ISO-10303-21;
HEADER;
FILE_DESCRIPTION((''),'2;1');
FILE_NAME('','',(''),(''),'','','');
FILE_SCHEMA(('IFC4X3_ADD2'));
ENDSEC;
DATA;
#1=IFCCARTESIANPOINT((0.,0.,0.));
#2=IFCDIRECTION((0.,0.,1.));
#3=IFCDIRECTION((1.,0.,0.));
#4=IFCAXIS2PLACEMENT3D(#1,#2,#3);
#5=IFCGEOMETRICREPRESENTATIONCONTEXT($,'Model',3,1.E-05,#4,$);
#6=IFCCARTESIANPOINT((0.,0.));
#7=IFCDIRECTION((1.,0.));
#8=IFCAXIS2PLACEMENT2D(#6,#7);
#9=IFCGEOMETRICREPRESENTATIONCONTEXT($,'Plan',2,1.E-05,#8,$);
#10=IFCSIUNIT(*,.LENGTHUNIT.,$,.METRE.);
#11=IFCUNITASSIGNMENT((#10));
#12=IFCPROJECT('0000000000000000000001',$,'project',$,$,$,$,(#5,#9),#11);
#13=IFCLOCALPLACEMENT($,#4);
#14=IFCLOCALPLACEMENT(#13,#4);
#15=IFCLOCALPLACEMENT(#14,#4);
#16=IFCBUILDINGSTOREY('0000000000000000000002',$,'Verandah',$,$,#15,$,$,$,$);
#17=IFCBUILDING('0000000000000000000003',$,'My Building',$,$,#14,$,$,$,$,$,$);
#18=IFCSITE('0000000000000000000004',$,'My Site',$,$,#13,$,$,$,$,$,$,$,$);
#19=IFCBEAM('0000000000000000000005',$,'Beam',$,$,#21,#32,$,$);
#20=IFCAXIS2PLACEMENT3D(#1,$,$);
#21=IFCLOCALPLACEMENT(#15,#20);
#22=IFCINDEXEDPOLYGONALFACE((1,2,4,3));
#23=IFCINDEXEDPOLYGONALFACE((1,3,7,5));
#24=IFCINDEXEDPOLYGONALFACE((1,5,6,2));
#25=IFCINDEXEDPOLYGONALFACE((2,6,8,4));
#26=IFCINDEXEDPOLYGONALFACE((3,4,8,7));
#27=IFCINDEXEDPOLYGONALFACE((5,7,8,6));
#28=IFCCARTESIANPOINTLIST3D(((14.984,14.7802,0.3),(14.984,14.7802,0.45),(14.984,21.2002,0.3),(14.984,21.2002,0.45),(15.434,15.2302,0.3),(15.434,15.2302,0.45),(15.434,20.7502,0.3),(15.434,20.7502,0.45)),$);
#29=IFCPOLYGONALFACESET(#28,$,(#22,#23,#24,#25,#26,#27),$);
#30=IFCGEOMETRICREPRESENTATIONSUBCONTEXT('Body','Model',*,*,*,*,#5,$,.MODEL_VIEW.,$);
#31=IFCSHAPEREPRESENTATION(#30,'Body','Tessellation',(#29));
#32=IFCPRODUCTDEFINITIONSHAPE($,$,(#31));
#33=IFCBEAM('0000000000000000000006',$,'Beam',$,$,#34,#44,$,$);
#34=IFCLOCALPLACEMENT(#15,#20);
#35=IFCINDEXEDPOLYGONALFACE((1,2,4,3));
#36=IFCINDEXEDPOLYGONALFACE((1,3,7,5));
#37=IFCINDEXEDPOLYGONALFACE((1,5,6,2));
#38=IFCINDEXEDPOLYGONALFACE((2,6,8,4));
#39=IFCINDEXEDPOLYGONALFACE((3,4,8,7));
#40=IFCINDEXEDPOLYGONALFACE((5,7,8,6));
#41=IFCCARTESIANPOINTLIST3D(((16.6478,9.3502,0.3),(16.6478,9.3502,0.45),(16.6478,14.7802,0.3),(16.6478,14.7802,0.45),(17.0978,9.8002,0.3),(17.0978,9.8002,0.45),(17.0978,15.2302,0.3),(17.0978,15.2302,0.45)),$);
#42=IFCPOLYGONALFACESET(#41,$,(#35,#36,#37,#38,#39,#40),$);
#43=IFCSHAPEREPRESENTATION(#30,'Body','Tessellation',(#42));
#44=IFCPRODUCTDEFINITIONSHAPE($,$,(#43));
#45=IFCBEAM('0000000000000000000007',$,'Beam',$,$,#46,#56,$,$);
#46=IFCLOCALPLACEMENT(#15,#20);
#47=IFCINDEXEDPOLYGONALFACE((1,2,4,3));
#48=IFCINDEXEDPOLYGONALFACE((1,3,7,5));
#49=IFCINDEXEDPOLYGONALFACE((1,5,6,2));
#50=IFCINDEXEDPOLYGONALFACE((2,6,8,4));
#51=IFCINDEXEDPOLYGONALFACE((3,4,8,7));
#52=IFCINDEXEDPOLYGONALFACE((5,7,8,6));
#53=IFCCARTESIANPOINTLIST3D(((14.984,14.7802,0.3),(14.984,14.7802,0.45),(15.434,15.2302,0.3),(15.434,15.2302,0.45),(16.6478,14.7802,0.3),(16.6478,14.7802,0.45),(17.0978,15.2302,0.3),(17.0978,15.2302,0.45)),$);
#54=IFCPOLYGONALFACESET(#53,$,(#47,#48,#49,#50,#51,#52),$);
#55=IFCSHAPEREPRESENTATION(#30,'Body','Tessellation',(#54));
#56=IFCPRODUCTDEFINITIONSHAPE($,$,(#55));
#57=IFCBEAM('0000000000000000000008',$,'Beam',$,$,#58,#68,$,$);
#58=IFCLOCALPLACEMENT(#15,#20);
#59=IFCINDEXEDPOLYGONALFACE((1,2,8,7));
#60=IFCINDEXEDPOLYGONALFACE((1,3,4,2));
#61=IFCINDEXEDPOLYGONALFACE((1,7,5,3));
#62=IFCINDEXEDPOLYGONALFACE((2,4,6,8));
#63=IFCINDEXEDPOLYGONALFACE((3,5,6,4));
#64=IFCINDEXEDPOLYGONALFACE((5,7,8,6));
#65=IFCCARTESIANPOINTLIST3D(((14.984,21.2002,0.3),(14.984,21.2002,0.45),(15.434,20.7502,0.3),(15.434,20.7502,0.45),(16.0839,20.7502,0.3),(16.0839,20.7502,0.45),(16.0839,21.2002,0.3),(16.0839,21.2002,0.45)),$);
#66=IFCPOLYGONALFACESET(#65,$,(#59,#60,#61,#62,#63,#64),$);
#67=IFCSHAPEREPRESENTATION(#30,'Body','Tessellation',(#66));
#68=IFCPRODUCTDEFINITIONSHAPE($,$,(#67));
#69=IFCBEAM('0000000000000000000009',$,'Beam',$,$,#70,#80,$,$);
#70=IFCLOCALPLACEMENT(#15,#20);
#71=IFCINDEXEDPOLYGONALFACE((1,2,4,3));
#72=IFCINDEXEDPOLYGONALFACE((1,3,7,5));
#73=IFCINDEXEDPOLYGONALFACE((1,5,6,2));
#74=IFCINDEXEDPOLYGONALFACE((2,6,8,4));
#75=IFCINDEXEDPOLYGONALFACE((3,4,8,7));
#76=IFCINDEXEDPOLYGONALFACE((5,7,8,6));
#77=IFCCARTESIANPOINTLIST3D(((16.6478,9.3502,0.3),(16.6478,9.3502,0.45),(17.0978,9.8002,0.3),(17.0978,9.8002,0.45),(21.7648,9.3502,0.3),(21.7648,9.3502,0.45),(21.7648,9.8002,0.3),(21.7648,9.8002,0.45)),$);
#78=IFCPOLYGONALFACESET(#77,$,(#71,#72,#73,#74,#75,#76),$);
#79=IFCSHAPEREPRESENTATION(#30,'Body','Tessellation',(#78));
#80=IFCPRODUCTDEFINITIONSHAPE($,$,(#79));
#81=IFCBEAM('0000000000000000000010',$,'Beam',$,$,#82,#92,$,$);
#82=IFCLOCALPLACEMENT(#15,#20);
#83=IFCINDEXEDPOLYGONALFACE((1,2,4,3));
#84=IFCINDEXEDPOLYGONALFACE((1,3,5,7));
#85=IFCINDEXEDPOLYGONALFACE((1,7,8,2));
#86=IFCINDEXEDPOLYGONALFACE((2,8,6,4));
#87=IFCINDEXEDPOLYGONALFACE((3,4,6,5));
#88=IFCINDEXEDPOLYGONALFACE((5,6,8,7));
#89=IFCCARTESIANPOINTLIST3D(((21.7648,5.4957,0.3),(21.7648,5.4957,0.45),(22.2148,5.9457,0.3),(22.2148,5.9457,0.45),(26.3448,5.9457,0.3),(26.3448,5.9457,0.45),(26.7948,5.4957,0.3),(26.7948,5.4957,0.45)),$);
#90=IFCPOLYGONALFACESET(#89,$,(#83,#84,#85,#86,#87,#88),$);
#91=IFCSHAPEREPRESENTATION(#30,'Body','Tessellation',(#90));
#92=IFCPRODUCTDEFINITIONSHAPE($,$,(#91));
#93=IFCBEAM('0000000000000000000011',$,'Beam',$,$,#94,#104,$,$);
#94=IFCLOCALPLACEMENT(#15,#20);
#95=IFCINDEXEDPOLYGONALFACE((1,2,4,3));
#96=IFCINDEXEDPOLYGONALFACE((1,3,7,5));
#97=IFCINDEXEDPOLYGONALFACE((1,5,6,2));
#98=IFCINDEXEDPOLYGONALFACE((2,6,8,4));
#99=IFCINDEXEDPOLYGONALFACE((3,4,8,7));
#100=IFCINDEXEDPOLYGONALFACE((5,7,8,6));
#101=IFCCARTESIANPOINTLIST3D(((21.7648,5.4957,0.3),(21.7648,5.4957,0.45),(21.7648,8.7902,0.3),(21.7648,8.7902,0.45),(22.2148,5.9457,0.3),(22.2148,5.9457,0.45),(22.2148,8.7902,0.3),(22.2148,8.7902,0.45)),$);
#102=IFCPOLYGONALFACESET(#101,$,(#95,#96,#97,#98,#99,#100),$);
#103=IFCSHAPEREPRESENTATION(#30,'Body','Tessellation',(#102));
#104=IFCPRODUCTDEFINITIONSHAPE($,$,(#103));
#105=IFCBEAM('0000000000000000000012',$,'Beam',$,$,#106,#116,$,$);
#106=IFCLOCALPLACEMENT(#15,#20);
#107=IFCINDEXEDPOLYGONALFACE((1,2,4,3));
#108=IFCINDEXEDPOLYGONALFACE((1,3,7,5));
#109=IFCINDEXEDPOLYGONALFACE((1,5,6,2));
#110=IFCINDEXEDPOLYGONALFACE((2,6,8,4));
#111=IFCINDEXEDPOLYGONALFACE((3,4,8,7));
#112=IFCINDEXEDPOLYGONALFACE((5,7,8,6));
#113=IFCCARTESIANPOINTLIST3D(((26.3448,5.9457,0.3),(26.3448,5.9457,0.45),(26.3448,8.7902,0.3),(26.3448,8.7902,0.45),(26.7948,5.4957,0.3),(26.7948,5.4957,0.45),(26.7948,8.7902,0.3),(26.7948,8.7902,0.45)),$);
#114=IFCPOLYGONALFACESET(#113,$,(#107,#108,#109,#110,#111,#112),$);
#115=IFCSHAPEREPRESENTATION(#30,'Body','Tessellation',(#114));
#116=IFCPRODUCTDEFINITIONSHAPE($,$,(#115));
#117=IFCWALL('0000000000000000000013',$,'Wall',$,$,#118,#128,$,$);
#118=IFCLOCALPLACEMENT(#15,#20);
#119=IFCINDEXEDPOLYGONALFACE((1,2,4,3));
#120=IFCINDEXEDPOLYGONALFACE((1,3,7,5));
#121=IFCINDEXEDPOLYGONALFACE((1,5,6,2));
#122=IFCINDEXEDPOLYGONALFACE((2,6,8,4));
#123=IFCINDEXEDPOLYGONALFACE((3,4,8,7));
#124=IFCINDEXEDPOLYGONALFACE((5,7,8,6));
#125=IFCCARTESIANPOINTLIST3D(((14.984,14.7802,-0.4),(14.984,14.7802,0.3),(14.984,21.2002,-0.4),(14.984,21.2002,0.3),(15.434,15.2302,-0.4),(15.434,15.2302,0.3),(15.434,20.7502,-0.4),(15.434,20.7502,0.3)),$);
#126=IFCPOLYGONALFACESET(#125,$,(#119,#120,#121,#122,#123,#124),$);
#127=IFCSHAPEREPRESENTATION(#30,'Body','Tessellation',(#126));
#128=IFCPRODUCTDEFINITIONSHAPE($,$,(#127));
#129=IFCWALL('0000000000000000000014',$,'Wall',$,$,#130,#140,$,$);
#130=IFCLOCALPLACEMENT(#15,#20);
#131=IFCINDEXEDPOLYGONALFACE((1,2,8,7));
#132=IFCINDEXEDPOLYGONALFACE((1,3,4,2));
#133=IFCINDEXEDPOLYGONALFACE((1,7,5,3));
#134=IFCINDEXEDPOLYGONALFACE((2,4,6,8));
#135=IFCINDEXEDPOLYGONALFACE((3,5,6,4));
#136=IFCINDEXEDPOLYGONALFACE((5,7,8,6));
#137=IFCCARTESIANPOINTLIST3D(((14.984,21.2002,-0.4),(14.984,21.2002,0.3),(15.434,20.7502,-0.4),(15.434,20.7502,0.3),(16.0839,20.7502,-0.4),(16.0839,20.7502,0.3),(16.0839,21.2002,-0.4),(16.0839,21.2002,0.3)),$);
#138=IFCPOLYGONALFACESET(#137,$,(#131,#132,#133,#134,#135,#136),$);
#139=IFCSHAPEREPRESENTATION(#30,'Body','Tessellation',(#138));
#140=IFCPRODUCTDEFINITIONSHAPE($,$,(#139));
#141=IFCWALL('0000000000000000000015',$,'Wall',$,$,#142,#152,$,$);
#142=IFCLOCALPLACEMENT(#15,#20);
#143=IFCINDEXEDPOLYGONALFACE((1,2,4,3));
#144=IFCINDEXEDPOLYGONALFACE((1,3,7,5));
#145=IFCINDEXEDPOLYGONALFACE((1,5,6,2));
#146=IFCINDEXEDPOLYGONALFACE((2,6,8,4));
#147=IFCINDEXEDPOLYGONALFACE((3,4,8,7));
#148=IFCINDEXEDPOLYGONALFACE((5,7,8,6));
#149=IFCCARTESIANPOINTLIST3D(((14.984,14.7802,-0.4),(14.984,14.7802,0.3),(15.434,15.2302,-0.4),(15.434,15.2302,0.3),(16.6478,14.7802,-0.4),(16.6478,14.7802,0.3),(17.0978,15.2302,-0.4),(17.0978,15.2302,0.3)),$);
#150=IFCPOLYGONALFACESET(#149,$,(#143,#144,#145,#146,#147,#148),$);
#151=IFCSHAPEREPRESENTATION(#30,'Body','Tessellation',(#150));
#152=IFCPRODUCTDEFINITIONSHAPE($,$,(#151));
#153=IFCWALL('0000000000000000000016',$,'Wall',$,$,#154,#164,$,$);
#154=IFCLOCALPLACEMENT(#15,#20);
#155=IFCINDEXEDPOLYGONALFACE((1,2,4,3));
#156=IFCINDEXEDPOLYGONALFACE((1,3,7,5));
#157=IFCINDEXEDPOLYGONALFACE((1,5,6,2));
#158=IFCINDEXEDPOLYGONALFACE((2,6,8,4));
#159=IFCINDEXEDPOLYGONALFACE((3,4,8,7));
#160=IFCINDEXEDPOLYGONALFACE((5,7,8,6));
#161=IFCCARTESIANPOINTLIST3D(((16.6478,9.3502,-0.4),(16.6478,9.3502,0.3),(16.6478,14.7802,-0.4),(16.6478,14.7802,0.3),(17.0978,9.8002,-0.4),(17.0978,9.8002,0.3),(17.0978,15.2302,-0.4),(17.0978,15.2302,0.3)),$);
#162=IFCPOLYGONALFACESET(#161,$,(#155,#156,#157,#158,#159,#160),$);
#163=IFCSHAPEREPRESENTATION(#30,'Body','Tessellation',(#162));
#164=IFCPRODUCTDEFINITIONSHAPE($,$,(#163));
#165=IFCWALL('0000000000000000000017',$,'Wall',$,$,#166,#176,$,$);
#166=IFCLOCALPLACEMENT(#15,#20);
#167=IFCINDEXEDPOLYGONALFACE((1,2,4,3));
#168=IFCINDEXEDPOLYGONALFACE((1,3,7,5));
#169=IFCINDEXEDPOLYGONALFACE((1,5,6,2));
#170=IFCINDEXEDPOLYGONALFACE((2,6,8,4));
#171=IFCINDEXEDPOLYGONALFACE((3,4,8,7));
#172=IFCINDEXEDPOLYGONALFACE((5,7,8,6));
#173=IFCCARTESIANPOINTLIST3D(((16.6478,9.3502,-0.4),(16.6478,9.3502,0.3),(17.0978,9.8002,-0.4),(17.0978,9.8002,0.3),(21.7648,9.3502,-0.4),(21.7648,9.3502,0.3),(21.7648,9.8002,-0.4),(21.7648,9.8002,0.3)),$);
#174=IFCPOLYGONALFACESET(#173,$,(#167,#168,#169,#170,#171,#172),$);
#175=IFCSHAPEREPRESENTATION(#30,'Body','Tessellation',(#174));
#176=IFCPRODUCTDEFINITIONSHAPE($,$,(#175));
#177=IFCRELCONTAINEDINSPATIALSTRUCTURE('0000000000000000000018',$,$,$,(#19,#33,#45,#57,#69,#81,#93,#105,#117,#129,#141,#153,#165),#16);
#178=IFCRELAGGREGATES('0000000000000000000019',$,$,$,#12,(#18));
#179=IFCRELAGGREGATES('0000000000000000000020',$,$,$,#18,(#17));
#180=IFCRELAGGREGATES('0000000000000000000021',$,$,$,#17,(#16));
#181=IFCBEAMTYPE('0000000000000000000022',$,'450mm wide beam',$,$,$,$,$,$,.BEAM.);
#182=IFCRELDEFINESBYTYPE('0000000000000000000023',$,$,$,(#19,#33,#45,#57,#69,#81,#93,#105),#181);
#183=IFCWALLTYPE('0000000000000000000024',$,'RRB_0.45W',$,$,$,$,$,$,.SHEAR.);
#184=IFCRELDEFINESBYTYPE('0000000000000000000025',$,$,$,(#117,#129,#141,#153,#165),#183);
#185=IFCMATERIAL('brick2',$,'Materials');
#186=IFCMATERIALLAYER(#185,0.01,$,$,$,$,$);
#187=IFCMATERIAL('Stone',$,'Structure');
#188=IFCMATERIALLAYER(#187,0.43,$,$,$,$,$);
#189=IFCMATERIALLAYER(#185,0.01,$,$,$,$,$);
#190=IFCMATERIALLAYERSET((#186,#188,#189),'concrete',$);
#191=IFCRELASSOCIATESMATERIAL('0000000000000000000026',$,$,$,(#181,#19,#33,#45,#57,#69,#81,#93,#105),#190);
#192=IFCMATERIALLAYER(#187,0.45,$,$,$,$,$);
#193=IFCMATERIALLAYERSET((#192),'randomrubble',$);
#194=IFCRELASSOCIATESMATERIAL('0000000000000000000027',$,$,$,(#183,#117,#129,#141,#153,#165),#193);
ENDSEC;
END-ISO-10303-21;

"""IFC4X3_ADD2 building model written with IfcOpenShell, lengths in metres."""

from ifc_helpers import new_model, si_unit, frame, origin_with_axes, origin_2d_with_axis, place, context, subcontext, project, spatial, line, indexed_curve, outline, extrude, material, layer, layer_set, layer_usage, type_object, element, save


model = new_model("IFC4X3_ADD2")

# Units and contexts
model_context = context("Model", 3, precision=1e-05, world=origin_with_axes())
plan_context = context("Plan", 2, precision=1e-05, world=origin_2d_with_axis())
body_context = subcontext(model_context, "Body", "Model", "MODEL_VIEW")
ifc_project = project(units=[si_unit("LENGTHUNIT", "METRE")], contexts=[model_context, plan_context])

# Site, building, storey
site_placement = place(None, origin_with_axes())
site = spatial("IfcSite", under=ifc_project, at=site_placement, Name="My Site")
building_placement = place(site_placement, origin_with_axes())
building = spatial("IfcBuilding", under=site, at=building_placement, Name="My Building")
storey_placement = place(building_placement, origin_with_axes())
storey = spatial("IfcBuildingStorey", under=building, at=storey_placement, Name="Verandah")

# Beams
ifc_material_1 = material(Name="brick2", Category="Materials")
ifc_layer_1 = layer(ifc_material_1, 0.01)
ifc_material_2 = material(Name="Stone", Category="Structure")
ifc_layer_2 = layer(ifc_material_2, 0.43)
ifc_layer_3 = layer(ifc_material_1, 0.01)
ifc_layer_set_1 = layer_set([ifc_layer_1, ifc_layer_2, ifc_layer_3], Name="concrete")
ifc_layer_usage_1 = layer_usage(ifc_layer_set_1, "AXIS2", "POSITIVE", 0.0)
beam_type = type_object("IfcBeamType", Name="450mm wide beam", PredefinedType="BEAM", material=ifc_layer_set_1)
beam_1_placement = place(storey_placement, frame((14.984, 21.2002, 0.3), z_axis=(0.0, 0.0, 1.0), x_axis=(0.0, -1.0, 0.0)))
element("IfcBeam", 1, at=beam_1_placement, inside=storey, type_object=beam_type, material=ifc_layer_usage_1, Name="Beam", context=body_context, shape_type="SweptSolid", body=[
    extrude(outline(indexed_curve([(0.0, 0.0), (0.45, 0.45), (5.97, 0.45), (6.42, 0.0)], segments=[line(1, 2, 3, 4, 1)])), origin_with_axes(), (0.0, 0.0, 1.0), 0.15),
])
ifc_layer_usage_2 = layer_usage(ifc_layer_set_1, "AXIS2", "POSITIVE", 0.0)
beam_2_placement = place(storey_placement, frame((16.6478, 15.2302, 0.3), z_axis=(0.0, 0.0, 1.0), x_axis=(0.0, -1.0, 0.0)))
element("IfcBeam", 2, at=beam_2_placement, inside=storey, type_object=beam_type, material=ifc_layer_usage_2, Name="Beam", context=body_context, shape_type="SweptSolid", body=[
    extrude(outline(indexed_curve([(0.45, 0.0), (0.0, 0.45), (5.43, 0.45), (5.88, 0.0)], segments=[line(1, 2, 3, 4, 1)])), origin_with_axes(), (0.0, 0.0, 1.0), 0.15),
])
ifc_layer_usage_3 = layer_usage(ifc_layer_set_1, "AXIS2", "NEGATIVE", 0.0)
beam_3_placement = place(storey_placement, frame((14.984, 15.2302, 0.3), z_axis=(0.0, 0.0, 1.0), x_axis=(1.0, 0.0, 0.0)))
element("IfcBeam", 3, at=beam_3_placement, inside=storey, type_object=beam_type, material=ifc_layer_usage_3, Name="Beam", context=body_context, shape_type="SweptSolid", body=[
    extrude(outline(indexed_curve([(0.0, -0.45), (0.45, 0.0), (2.1138, 0.0), (1.6638, -0.45)], segments=[line(1, 2, 3, 4, 1)])), origin_with_axes(), (0.0, 0.0, 1.0), 0.15),
])
ifc_layer_usage_4 = layer_usage(ifc_layer_set_1, "AXIS2", "NEGATIVE", 0.0)
beam_4_placement = place(storey_placement, frame((14.984, 21.2002, 0.3), z_axis=(0.0, 0.0, 1.0), x_axis=(1.0, 0.0, 0.0)))
element("IfcBeam", 4, at=beam_4_placement, inside=storey, type_object=beam_type, material=ifc_layer_usage_4, Name="Beam", context=body_context, shape_type="SweptSolid", body=[
    extrude(outline(indexed_curve([(0.45, -0.45), (0.0, 0.0), (1.1, 0.0), (1.1, -0.45)], segments=[line(1, 2, 3, 4, 1)])), origin_with_axes(), (0.0, 0.0, 1.0), 0.15),
])
ifc_layer_usage_5 = layer_usage(ifc_layer_set_1, "AXIS2", "NEGATIVE", 0.0)
beam_5_placement = place(storey_placement, frame((16.6478, 9.8002, 0.3), z_axis=(0.0, 0.0, 1.0), x_axis=(1.0, 0.0, 0.0)))
element("IfcBeam", 5, at=beam_5_placement, inside=storey, type_object=beam_type, material=ifc_layer_usage_5, Name="Beam", context=body_context, shape_type="SweptSolid", body=[
    extrude(outline(indexed_curve([(0.0, -0.45), (0.45, 0.0), (5.117, 0.0), (5.117, -0.45)], segments=[line(1, 2, 3, 4, 1)])), origin_with_axes(), (0.0, 0.0, 1.0), 0.15),
])
ifc_layer_usage_6 = layer_usage(ifc_layer_set_1, "AXIS2", "NEGATIVE", 0.0)
beam_6_placement = place(storey_placement, frame((21.7648, 5.9457, 0.3), z_axis=(0.0, 0.0, 1.0), x_axis=(1.0, 0.0, 0.0)))
element("IfcBeam", 6, at=beam_6_placement, inside=storey, type_object=beam_type, material=ifc_layer_usage_6, Name="Beam", context=body_context, shape_type="SweptSolid", body=[
    extrude(outline(indexed_curve([(0.0, -0.45), (0.45, 0.0), (4.58, 0.0), (5.03, -0.45)], segments=[line(1, 2, 3, 4, 1)])), origin_with_axes(), (0.0, 0.0, 1.0), 0.15),
])
ifc_layer_usage_7 = layer_usage(ifc_layer_set_1, "AXIS2", "POSITIVE", 0.0)
beam_7_placement = place(storey_placement, frame((21.7648, 8.7902, 0.3), z_axis=(0.0, 0.0, 1.0), x_axis=(0.0, -1.0, 0.0)))
element("IfcBeam", 7, at=beam_7_placement, inside=storey, type_object=beam_type, material=ifc_layer_usage_7, Name="Beam", context=body_context, shape_type="SweptSolid", body=[
    extrude(outline(indexed_curve([(0.0, 0.0), (0.0, 0.45), (2.8445, 0.45), (3.2945, 0.0)], segments=[line(1, 2, 3, 4, 1)])), origin_with_axes(), (0.0, 0.0, 1.0), 0.15),
])
ifc_layer_usage_8 = layer_usage(ifc_layer_set_1, "AXIS2", "POSITIVE", 0.0)
beam_8_placement = place(storey_placement, frame((26.3448, 8.7902, 0.3), z_axis=(0.0, 0.0, 1.0), x_axis=(0.0, -1.0, 0.0)))
element("IfcBeam", 8, at=beam_8_placement, inside=storey, type_object=beam_type, material=ifc_layer_usage_8, Name="Beam", context=body_context, shape_type="SweptSolid", body=[
    extrude(outline(indexed_curve([(0.0, 0.0), (0.0, 0.45), (3.2945, 0.45), (2.8445, 0.0)], segments=[line(1, 2, 3, 4, 1)])), origin_with_axes(), (0.0, 0.0, 1.0), 0.15),
])

# Walls
ifc_layer_4 = layer(ifc_material_2, 0.45)
ifc_layer_set_2 = layer_set([ifc_layer_4], Name="randomrubble")
ifc_layer_usage_9 = layer_usage(ifc_layer_set_2, "AXIS2", "POSITIVE", 0.0)
wall_type_1 = type_object("IfcWallType", Name="RRB_0.45W", PredefinedType="SHEAR", material=ifc_layer_set_2)
wall_1_placement = place(storey_placement, frame((15.434, 14.7802, -0.4), z_axis=(0.0, 0.0, 1.0), x_axis=(0.000001, 1.0, 0.0)))
element("IfcWall", 9, at=wall_1_placement, inside=storey, type_object=wall_type_1, material=ifc_layer_usage_9, Name="Wall", context=body_context, shape_type="SweptSolid", body=[
    extrude(outline(indexed_curve([(0.45, 0.0), (0.0, 0.45), (6.42, 0.45), (5.97, 0.0)], segments=[line(1, 2, 3, 4, 1)])), origin_with_axes(), (0.0, 0.0, 1.0), 0.7),
])
ifc_layer_usage_10 = layer_usage(ifc_layer_set_2, "AXIS2", "POSITIVE", 0.0)
wall_2_placement = place(storey_placement, frame((15.434, 20.7502, -0.4), z_axis=(0.0, 0.0, 1.0), x_axis=(1.0, 0.0, 0.0)))
element("IfcWall", 10, at=wall_2_placement, inside=storey, type_object=wall_type_1, material=ifc_layer_usage_10, Name="Wall", context=body_context, shape_type="SweptSolid", body=[
    extrude(outline(indexed_curve([(0.0, 0.0), (-0.45, 0.45), (0.6499, 0.45), (0.6499, 0.0)], segments=[line(1, 2, 3, 4, 1)])), origin_with_axes(), (0.0, 0.0, 1.0), 0.7),
])
ifc_layer_usage_11 = layer_usage(ifc_layer_set_2, "AXIS2", "POSITIVE", 0.0)
wall_3_placement = place(storey_placement, frame((15.434, 14.7802, -0.4), z_axis=(0.0, 0.0, 1.0), x_axis=(1.0, 0.0, 0.0)))
element("IfcWall", 11, at=wall_3_placement, inside=storey, type_object=wall_type_1, material=ifc_layer_usage_11, Name="Wall", context=body_context, shape_type="SweptSolid", body=[
    extrude(outline(indexed_curve([(-0.45, 0.0), (0.0, 0.45), (1.6638, 0.45), (1.2138, 0.0)], segments=[line(1, 2, 3, 4, 1)])), origin_with_axes(), (0.0, 0.0, 1.0), 0.7),
])
ifc_layer_usage_12 = layer_usage(ifc_layer_set_2, "AXIS2", "POSITIVE", 0.0)
wall_4_placement = place(storey_placement, frame((17.0978, 9.3502, -0.4), z_axis=(0.0, 0.0, 1.0), x_axis=(0.000001, 1.0, 0.0)))
element("IfcWall", 12, at=wall_4_placement, inside=storey, type_object=wall_type_1, material=ifc_layer_usage_12, Name="Wall", context=body_context, shape_type="SweptSolid", body=[
    extrude(outline(indexed_curve([(0.45, 0.0), (0.0, 0.45), (5.43, 0.45), (5.88, 0.0)], segments=[line(1, 2, 3, 4, 1)])), origin_with_axes(), (0.0, 0.0, 1.0), 0.7),
])
ifc_layer_usage_13 = layer_usage(ifc_layer_set_2, "AXIS2", "POSITIVE", 0.0)
wall_5_placement = place(storey_placement, frame((17.0978, 9.3502, -0.4), z_axis=(0.0, 0.0, 1.0), x_axis=(1.0, 0.0, 0.0)))
element("IfcWall", 13, at=wall_5_placement, inside=storey, type_object=wall_type_1, material=ifc_layer_usage_13, Name="Wall", context=body_context, shape_type="SweptSolid", body=[
    extrude(outline(indexed_curve([(-0.45, 0.0), (0.0, 0.45), (4.667, 0.45), (4.667, 0.0)], segments=[line(1, 2, 3, 4, 1)])), origin_with_axes(), (0.0, 0.0, 1.0), 0.7),
])

save(model, "model.ifc")
